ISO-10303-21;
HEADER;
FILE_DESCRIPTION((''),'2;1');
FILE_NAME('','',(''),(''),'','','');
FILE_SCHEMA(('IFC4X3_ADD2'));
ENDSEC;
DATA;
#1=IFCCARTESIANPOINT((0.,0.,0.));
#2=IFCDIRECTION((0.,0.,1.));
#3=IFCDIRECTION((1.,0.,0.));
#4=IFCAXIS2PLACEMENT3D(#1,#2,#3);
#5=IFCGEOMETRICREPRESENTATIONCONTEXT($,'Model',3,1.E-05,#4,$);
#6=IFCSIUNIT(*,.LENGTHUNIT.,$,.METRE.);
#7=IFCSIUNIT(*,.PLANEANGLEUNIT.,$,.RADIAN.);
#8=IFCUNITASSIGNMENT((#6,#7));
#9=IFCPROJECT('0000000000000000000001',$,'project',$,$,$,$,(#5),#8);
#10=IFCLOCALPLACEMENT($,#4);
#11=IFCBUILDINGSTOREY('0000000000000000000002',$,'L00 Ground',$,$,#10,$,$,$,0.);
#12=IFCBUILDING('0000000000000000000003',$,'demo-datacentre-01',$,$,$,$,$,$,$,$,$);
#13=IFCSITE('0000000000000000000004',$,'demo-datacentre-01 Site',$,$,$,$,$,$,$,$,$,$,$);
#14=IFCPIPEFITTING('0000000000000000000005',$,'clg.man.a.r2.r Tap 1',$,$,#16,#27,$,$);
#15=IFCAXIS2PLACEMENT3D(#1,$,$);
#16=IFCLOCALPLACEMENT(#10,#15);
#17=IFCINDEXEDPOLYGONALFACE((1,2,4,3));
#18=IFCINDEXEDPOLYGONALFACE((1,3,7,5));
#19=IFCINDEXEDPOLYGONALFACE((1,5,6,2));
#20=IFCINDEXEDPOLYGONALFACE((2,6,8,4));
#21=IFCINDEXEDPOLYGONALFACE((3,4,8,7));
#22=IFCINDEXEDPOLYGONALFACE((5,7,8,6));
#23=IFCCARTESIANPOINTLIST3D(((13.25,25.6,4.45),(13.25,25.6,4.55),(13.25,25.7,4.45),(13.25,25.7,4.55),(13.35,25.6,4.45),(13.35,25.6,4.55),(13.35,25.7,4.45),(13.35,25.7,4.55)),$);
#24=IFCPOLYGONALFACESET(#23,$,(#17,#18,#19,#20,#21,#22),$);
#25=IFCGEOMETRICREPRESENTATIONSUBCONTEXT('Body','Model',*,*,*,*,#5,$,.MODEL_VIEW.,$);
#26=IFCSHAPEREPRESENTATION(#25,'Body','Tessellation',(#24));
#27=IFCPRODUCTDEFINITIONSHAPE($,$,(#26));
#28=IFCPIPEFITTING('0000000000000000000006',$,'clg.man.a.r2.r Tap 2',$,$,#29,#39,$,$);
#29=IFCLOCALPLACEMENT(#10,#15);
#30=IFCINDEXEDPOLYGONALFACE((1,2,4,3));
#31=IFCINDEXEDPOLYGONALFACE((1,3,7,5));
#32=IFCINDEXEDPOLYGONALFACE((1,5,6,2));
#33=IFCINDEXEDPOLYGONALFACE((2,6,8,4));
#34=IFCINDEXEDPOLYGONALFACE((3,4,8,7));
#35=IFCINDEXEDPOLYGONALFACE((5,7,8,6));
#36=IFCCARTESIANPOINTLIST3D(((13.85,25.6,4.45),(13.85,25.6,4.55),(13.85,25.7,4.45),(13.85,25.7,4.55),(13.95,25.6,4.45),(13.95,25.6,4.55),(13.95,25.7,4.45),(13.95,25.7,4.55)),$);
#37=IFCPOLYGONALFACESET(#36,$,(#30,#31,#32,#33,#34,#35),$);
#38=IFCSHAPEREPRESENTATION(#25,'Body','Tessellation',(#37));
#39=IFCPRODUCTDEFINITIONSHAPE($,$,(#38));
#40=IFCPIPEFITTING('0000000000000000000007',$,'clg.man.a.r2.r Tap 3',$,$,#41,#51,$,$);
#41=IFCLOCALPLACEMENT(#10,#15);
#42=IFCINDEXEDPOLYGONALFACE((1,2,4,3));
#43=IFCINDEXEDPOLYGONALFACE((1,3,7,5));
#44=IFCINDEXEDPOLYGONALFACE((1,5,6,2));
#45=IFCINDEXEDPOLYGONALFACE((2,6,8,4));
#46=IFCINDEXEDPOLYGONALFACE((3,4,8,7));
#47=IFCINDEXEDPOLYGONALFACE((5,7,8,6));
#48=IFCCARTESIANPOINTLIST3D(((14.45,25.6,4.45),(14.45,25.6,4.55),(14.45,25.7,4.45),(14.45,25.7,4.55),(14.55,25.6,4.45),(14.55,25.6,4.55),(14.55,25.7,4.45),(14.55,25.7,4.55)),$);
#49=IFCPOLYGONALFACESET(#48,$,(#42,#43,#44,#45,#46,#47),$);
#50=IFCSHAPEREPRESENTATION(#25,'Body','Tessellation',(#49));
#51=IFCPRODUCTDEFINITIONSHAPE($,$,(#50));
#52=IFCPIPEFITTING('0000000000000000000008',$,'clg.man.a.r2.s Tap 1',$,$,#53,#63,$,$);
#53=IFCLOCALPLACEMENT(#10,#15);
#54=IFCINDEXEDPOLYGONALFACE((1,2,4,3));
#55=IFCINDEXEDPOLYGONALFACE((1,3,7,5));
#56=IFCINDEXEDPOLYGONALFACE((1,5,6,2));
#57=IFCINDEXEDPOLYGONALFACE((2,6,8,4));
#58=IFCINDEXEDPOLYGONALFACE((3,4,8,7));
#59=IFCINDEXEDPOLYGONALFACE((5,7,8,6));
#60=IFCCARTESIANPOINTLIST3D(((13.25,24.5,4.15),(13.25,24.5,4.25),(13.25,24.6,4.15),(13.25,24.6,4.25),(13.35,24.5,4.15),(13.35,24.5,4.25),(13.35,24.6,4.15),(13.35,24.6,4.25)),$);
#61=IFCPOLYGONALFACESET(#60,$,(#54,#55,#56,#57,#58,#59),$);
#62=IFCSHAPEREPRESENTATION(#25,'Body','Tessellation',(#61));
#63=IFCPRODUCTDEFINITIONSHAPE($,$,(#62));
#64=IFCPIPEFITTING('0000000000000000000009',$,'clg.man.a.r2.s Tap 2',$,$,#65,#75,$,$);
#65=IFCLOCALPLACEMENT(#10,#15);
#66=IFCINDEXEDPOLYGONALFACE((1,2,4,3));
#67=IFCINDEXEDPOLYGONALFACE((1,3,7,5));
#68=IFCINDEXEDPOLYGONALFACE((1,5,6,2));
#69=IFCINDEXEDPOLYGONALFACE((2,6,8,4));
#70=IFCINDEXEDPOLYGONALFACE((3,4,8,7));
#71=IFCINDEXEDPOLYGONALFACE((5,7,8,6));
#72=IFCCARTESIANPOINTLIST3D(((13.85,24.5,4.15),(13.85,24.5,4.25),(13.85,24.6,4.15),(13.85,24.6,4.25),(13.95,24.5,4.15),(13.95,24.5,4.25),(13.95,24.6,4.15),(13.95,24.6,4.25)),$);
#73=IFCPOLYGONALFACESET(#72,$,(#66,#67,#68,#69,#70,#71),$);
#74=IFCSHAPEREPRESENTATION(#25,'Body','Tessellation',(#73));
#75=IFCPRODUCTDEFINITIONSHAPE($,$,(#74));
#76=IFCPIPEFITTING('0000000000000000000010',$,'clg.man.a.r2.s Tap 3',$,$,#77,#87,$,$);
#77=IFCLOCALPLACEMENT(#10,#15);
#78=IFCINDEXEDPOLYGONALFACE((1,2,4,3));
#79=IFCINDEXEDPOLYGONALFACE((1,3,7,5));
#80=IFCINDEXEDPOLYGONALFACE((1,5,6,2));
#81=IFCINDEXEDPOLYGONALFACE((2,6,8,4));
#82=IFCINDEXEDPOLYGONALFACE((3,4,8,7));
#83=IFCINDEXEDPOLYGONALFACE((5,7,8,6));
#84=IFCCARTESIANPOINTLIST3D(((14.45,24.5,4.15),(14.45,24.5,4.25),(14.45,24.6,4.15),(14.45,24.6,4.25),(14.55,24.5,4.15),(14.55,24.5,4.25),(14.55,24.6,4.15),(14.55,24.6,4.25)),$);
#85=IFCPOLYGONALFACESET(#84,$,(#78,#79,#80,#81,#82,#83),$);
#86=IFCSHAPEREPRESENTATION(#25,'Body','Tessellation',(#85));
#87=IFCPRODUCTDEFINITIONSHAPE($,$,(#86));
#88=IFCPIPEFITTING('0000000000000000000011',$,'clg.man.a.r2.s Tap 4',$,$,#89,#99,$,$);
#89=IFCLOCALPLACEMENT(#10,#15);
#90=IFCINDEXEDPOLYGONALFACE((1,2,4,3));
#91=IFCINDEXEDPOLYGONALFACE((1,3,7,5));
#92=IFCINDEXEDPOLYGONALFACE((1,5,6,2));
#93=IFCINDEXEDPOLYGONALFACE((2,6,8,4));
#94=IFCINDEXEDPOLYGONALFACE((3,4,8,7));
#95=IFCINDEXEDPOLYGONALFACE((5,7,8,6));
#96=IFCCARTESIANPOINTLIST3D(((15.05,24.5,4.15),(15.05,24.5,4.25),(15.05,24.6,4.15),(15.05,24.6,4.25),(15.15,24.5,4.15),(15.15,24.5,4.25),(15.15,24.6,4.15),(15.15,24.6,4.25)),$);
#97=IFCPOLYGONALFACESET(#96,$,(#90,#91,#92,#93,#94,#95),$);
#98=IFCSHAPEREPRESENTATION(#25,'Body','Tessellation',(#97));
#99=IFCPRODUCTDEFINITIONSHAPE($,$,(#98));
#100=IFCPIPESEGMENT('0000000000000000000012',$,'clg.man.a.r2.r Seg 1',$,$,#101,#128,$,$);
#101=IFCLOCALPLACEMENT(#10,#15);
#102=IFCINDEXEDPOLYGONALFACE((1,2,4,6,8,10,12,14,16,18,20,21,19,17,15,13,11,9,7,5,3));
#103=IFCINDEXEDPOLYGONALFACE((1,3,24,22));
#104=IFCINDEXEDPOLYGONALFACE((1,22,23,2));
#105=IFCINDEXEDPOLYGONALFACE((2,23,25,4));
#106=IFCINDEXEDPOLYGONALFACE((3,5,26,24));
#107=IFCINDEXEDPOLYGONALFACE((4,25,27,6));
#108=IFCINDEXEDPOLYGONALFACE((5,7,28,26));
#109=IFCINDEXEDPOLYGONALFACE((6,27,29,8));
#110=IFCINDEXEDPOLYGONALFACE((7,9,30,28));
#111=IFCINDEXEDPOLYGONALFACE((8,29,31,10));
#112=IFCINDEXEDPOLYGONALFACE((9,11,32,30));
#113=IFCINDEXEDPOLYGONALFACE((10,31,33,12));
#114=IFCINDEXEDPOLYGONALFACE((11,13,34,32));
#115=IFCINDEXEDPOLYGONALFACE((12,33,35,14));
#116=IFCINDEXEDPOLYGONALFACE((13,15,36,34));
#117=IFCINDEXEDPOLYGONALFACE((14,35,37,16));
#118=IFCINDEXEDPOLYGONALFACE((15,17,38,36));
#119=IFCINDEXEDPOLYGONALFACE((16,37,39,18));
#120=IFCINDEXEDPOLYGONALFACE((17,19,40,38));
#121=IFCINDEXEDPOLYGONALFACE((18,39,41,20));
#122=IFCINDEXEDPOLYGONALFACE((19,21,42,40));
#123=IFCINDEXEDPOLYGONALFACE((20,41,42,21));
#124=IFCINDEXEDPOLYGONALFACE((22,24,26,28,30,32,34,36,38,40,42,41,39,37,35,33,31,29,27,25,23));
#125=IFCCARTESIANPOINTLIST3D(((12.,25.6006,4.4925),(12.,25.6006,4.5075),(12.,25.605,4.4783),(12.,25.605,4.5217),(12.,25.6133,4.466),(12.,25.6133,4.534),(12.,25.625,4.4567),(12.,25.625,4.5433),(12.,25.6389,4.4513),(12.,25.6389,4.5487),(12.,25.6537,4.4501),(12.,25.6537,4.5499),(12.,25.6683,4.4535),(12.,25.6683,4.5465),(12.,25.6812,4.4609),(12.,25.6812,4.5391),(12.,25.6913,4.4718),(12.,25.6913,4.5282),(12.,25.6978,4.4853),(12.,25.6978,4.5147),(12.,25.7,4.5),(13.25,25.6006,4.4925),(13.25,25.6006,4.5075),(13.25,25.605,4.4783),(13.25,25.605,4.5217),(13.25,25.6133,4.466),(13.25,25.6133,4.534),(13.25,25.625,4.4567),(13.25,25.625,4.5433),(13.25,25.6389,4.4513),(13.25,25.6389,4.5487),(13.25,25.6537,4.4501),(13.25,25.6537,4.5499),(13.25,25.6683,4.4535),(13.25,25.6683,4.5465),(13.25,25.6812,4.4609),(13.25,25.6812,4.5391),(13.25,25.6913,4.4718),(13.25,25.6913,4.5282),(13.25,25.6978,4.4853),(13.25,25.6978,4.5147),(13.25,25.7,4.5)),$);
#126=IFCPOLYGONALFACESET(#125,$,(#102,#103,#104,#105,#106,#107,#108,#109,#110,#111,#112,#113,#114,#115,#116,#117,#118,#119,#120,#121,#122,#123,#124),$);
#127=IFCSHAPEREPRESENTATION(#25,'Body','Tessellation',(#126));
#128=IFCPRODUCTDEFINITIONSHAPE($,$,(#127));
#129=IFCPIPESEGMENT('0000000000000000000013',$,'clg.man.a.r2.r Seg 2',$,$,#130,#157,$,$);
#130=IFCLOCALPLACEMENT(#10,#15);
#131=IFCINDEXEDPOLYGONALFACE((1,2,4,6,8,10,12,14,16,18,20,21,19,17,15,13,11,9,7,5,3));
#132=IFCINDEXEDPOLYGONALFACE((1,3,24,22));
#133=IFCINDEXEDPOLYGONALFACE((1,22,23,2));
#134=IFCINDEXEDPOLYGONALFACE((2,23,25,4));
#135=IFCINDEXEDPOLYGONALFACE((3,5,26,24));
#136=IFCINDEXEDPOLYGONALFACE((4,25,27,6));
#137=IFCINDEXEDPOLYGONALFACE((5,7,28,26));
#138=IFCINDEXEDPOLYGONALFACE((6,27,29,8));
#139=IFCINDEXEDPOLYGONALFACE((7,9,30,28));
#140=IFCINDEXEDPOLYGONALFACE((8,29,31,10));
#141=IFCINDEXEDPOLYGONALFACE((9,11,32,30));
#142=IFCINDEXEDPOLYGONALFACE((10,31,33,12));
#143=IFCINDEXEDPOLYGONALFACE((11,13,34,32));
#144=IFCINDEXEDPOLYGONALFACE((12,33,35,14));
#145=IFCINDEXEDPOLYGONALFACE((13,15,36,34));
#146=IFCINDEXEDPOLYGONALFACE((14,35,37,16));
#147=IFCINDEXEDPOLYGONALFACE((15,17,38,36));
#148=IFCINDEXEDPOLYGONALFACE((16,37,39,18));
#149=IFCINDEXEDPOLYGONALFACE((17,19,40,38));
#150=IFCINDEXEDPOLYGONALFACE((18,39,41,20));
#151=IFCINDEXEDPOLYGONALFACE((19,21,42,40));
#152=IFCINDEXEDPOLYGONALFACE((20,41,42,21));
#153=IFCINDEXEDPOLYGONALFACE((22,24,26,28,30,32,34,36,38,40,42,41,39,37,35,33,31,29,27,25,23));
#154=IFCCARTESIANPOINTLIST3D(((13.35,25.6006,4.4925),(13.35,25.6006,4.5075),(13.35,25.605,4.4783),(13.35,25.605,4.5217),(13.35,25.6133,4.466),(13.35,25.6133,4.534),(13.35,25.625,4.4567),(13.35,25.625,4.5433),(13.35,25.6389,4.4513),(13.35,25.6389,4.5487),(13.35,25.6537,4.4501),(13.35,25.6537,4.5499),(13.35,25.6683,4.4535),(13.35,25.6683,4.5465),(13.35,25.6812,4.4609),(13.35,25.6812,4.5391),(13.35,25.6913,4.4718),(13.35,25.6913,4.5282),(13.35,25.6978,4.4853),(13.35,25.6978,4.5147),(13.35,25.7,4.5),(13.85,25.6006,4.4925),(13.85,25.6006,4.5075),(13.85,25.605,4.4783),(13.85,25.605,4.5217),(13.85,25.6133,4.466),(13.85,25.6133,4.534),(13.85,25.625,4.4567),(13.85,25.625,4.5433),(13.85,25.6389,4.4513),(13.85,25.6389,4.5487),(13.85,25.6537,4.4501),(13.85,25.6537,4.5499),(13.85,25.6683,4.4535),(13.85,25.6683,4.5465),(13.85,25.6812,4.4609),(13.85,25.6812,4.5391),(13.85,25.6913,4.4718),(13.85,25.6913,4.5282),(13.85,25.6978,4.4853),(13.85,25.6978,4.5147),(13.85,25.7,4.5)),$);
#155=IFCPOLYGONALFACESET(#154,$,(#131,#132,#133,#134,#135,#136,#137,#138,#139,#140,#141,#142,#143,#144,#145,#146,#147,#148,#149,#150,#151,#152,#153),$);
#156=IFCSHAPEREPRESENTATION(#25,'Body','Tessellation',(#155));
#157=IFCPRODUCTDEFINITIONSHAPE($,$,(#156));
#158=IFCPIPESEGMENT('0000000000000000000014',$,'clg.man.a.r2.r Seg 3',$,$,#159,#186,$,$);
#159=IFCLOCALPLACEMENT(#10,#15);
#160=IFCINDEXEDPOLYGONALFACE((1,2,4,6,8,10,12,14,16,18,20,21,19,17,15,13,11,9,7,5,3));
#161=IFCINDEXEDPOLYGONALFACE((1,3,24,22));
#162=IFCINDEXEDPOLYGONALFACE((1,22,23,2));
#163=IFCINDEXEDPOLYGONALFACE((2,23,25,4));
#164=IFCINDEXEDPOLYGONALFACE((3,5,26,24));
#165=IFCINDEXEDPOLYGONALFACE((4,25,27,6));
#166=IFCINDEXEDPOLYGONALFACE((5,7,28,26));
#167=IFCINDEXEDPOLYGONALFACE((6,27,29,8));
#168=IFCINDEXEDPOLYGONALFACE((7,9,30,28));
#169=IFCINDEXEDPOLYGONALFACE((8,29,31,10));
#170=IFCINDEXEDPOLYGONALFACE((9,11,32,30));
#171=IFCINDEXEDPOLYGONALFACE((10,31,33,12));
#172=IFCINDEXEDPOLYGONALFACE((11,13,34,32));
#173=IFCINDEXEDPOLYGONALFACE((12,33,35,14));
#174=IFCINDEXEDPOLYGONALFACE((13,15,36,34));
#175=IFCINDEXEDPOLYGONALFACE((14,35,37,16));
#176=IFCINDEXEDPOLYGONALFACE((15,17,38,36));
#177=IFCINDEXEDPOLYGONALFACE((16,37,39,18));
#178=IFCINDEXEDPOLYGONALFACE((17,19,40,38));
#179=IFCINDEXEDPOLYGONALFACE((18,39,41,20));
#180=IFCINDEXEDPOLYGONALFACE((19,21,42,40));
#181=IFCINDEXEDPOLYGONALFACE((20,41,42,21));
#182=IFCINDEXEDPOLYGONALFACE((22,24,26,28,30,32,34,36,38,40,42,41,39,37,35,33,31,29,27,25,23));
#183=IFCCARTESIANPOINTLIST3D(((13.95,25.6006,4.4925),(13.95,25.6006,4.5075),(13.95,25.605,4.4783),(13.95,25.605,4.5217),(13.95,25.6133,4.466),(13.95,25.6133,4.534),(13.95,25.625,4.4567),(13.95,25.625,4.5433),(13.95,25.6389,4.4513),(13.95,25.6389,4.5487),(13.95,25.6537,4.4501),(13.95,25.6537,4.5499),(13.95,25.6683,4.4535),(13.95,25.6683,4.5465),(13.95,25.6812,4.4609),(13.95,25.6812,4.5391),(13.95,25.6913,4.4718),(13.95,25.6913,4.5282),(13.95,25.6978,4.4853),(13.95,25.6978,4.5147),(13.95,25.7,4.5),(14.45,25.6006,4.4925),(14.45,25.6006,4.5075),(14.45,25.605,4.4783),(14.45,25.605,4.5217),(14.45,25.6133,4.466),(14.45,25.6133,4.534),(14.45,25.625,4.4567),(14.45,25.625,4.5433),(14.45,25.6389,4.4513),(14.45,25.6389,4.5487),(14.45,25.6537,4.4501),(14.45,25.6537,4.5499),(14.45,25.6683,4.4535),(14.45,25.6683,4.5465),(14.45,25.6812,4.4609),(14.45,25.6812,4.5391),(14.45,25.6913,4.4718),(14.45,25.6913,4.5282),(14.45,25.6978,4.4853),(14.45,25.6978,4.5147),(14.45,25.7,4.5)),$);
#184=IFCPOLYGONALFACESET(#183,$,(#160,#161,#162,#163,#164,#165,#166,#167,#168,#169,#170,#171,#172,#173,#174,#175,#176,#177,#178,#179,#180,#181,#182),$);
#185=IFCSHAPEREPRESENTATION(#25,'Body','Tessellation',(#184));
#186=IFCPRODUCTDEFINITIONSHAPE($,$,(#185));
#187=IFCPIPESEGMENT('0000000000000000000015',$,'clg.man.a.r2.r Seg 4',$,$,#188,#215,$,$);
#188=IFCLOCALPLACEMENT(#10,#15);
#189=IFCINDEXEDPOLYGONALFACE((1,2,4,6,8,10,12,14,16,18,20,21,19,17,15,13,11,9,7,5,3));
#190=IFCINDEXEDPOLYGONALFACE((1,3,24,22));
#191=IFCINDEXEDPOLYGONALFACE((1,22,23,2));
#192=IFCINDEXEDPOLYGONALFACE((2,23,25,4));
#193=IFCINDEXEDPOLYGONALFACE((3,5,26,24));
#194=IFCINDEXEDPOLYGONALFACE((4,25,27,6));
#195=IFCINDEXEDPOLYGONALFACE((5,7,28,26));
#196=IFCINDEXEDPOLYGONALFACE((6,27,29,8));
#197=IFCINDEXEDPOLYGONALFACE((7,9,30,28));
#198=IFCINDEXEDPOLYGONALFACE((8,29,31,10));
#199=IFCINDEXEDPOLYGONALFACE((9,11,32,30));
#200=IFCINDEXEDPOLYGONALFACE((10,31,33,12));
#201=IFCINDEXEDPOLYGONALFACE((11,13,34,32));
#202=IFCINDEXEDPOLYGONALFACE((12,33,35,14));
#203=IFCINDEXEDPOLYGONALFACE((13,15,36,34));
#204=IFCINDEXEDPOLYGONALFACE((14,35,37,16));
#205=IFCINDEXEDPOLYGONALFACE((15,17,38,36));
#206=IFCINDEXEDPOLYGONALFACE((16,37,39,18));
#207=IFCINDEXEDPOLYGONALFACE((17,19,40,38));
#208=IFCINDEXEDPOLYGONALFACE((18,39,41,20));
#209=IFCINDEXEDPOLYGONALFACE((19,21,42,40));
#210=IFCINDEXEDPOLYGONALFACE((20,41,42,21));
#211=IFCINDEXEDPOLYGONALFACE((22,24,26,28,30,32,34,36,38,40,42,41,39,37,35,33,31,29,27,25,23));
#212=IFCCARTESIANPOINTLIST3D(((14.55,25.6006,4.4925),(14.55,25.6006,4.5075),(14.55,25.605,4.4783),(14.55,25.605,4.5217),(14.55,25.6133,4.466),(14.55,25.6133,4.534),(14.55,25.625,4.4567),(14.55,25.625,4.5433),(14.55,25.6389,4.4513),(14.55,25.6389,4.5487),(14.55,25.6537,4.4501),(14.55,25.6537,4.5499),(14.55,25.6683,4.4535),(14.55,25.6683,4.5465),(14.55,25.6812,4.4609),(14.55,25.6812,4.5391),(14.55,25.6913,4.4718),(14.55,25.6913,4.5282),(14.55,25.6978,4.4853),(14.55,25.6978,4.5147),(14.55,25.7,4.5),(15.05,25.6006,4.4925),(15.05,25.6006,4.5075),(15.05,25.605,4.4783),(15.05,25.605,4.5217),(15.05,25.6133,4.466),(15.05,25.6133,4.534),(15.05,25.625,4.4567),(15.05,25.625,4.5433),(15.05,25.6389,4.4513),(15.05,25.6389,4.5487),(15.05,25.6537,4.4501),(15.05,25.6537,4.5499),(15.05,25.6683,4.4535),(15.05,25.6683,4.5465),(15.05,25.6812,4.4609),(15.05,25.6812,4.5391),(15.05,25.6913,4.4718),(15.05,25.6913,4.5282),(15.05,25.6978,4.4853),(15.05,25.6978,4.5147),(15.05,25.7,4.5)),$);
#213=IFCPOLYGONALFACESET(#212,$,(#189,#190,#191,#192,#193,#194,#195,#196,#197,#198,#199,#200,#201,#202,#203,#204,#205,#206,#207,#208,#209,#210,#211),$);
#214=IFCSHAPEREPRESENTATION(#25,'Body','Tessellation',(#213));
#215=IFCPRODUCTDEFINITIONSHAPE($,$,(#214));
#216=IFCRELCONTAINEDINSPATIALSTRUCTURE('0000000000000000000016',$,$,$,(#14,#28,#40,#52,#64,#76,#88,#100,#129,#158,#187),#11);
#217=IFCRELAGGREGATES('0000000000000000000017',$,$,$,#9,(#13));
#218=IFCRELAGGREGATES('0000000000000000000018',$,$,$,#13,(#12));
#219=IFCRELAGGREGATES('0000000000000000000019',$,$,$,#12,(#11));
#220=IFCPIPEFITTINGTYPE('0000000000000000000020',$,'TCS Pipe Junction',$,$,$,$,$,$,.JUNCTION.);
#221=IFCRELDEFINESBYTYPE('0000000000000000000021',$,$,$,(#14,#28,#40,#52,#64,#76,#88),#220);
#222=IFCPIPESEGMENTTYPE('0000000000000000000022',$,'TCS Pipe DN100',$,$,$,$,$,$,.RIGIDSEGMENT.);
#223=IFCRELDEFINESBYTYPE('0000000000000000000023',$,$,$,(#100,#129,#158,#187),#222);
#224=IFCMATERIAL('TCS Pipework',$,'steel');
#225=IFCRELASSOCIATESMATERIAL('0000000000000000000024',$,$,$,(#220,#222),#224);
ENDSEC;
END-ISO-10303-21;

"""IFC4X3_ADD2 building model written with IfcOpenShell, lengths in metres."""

from ifc_helpers import new_model, si_unit, frame, origin_with_axes, place, context, subcontext, project, spatial, rectangle, circle, extrude, material, type_object, element, save


model = new_model("IFC4X3_ADD2")

# Units and contexts
model_context = context("Model", 3, precision=1e-05, world=origin_with_axes())
body_context = subcontext(model_context, "Body", "Model", "MODEL_VIEW")
ifc_project = project(units=[si_unit("LENGTHUNIT", "METRE"), si_unit("PLANEANGLEUNIT", "RADIAN")], contexts=[model_context])

# Site, building, storey
site = spatial("IfcSite", under=ifc_project, Name="demo-datacentre-01 Site")
building = spatial("IfcBuilding", under=site, Name="demo-datacentre-01")
storey_placement = place(None, origin_with_axes())
storey = spatial("IfcBuildingStorey", under=building, at=storey_placement, Name="L00 Ground", Elevation=0.0)

# Pipe fittings
ifc_material = material(Name="TCS Pipework", Category="steel")
pipe_fitting_type = type_object("IfcPipeFittingType", Name="TCS Pipe Junction", PredefinedType="JUNCTION", material=ifc_material)
for number, where, z_axis, x_axis, name in (
    (1, (13.3, 25.65, 4.45), (0.0, 0.0, 1.0), (1.0, 0.0, 0.0), "clg.man.a.r2.r Tap 1"),
    (2, (13.9, 25.65, 4.45), (0.0, 0.0, 1.0), (1.0, 0.0, 0.0), "clg.man.a.r2.r Tap 2"),
    (3, (14.5, 25.65, 4.45), (0.0, 0.0, 1.0), (1.0, 0.0, 0.0), "clg.man.a.r2.r Tap 3"),
    (4, (13.3, 24.55, 4.15), (0.0, 0.0, 1.0), (1.0, 0.0, 0.0), "clg.man.a.r2.s Tap 1"),
    (5, (13.9, 24.55, 4.15), (0.0, 0.0, 1.0), (1.0, 0.0, 0.0), "clg.man.a.r2.s Tap 2"),
    (6, (14.5, 24.55, 4.15), (0.0, 0.0, 1.0), (1.0, 0.0, 0.0), "clg.man.a.r2.s Tap 3"),
    (7, (15.1, 24.55, 4.15), (0.0, 0.0, 1.0), (1.0, 0.0, 0.0), "clg.man.a.r2.s Tap 4"),
):
    element("IfcPipeFitting", number, at=place(storey_placement, frame(where, z_axis=z_axis, x_axis=x_axis)), inside=storey, type_object=pipe_fitting_type, Name=name, context=body_context, shape_type="SweptSolid", body=[
        extrude(rectangle(XDim=0.1, YDim=0.1), origin_with_axes(), (0.0, 0.0, 1.0), 0.1),
    ])

# Pipe segments
pipe_segment_type_1 = type_object("IfcPipeSegmentType", Name="TCS Pipe DN100", PredefinedType="RIGIDSEGMENT", material=ifc_material)
pipe_segment_1_placement = place(storey_placement, frame((12.0, 25.65, 4.5), z_axis=(1.0, 0.0, 0.0), x_axis=(0.0, 1.0, 0.0)))
element("IfcPipeSegment", 8, at=pipe_segment_1_placement, inside=storey, type_object=pipe_segment_type_1, Name="clg.man.a.r2.r Seg 1", context=body_context, shape_type="SweptSolid", body=[
    extrude(circle(Radius=0.05), origin_with_axes(), (0.0, 0.0, 1.0), 1.25),
])
for number, where, z_axis, x_axis, name in (
    (9, (13.35, 25.65, 4.5), (1.0, 0.0, 0.0), (0.0, 1.0, 0.0), "clg.man.a.r2.r Seg 2"),
    (10, (13.95, 25.65, 4.5), (1.0, 0.0, 0.0), (0.0, 1.0, 0.0), "clg.man.a.r2.r Seg 3"),
):
    element("IfcPipeSegment", number, at=place(storey_placement, frame(where, z_axis=z_axis, x_axis=x_axis)), inside=storey, type_object=pipe_segment_type_1, Name=name, context=body_context, shape_type="SweptSolid", body=[
        extrude(circle(Radius=0.05), origin_with_axes(), (0.0, 0.0, 1.0), 0.5),
    ])
pipe_segment_2_placement = place(storey_placement, frame((14.55, 25.65, 4.5), z_axis=(1.0, 0.0, 0.0), x_axis=(0.0, 1.0, 0.0)))
element("IfcPipeSegment", 11, at=pipe_segment_2_placement, inside=storey, type_object=pipe_segment_type_1, Name="clg.man.a.r2.r Seg 4", context=body_context, shape_type="SweptSolid", body=[
    extrude(circle(Radius=0.05), origin_with_axes(), (0.0, 0.0, 1.0), 0.5),
])

save(model, "model.ifc")
